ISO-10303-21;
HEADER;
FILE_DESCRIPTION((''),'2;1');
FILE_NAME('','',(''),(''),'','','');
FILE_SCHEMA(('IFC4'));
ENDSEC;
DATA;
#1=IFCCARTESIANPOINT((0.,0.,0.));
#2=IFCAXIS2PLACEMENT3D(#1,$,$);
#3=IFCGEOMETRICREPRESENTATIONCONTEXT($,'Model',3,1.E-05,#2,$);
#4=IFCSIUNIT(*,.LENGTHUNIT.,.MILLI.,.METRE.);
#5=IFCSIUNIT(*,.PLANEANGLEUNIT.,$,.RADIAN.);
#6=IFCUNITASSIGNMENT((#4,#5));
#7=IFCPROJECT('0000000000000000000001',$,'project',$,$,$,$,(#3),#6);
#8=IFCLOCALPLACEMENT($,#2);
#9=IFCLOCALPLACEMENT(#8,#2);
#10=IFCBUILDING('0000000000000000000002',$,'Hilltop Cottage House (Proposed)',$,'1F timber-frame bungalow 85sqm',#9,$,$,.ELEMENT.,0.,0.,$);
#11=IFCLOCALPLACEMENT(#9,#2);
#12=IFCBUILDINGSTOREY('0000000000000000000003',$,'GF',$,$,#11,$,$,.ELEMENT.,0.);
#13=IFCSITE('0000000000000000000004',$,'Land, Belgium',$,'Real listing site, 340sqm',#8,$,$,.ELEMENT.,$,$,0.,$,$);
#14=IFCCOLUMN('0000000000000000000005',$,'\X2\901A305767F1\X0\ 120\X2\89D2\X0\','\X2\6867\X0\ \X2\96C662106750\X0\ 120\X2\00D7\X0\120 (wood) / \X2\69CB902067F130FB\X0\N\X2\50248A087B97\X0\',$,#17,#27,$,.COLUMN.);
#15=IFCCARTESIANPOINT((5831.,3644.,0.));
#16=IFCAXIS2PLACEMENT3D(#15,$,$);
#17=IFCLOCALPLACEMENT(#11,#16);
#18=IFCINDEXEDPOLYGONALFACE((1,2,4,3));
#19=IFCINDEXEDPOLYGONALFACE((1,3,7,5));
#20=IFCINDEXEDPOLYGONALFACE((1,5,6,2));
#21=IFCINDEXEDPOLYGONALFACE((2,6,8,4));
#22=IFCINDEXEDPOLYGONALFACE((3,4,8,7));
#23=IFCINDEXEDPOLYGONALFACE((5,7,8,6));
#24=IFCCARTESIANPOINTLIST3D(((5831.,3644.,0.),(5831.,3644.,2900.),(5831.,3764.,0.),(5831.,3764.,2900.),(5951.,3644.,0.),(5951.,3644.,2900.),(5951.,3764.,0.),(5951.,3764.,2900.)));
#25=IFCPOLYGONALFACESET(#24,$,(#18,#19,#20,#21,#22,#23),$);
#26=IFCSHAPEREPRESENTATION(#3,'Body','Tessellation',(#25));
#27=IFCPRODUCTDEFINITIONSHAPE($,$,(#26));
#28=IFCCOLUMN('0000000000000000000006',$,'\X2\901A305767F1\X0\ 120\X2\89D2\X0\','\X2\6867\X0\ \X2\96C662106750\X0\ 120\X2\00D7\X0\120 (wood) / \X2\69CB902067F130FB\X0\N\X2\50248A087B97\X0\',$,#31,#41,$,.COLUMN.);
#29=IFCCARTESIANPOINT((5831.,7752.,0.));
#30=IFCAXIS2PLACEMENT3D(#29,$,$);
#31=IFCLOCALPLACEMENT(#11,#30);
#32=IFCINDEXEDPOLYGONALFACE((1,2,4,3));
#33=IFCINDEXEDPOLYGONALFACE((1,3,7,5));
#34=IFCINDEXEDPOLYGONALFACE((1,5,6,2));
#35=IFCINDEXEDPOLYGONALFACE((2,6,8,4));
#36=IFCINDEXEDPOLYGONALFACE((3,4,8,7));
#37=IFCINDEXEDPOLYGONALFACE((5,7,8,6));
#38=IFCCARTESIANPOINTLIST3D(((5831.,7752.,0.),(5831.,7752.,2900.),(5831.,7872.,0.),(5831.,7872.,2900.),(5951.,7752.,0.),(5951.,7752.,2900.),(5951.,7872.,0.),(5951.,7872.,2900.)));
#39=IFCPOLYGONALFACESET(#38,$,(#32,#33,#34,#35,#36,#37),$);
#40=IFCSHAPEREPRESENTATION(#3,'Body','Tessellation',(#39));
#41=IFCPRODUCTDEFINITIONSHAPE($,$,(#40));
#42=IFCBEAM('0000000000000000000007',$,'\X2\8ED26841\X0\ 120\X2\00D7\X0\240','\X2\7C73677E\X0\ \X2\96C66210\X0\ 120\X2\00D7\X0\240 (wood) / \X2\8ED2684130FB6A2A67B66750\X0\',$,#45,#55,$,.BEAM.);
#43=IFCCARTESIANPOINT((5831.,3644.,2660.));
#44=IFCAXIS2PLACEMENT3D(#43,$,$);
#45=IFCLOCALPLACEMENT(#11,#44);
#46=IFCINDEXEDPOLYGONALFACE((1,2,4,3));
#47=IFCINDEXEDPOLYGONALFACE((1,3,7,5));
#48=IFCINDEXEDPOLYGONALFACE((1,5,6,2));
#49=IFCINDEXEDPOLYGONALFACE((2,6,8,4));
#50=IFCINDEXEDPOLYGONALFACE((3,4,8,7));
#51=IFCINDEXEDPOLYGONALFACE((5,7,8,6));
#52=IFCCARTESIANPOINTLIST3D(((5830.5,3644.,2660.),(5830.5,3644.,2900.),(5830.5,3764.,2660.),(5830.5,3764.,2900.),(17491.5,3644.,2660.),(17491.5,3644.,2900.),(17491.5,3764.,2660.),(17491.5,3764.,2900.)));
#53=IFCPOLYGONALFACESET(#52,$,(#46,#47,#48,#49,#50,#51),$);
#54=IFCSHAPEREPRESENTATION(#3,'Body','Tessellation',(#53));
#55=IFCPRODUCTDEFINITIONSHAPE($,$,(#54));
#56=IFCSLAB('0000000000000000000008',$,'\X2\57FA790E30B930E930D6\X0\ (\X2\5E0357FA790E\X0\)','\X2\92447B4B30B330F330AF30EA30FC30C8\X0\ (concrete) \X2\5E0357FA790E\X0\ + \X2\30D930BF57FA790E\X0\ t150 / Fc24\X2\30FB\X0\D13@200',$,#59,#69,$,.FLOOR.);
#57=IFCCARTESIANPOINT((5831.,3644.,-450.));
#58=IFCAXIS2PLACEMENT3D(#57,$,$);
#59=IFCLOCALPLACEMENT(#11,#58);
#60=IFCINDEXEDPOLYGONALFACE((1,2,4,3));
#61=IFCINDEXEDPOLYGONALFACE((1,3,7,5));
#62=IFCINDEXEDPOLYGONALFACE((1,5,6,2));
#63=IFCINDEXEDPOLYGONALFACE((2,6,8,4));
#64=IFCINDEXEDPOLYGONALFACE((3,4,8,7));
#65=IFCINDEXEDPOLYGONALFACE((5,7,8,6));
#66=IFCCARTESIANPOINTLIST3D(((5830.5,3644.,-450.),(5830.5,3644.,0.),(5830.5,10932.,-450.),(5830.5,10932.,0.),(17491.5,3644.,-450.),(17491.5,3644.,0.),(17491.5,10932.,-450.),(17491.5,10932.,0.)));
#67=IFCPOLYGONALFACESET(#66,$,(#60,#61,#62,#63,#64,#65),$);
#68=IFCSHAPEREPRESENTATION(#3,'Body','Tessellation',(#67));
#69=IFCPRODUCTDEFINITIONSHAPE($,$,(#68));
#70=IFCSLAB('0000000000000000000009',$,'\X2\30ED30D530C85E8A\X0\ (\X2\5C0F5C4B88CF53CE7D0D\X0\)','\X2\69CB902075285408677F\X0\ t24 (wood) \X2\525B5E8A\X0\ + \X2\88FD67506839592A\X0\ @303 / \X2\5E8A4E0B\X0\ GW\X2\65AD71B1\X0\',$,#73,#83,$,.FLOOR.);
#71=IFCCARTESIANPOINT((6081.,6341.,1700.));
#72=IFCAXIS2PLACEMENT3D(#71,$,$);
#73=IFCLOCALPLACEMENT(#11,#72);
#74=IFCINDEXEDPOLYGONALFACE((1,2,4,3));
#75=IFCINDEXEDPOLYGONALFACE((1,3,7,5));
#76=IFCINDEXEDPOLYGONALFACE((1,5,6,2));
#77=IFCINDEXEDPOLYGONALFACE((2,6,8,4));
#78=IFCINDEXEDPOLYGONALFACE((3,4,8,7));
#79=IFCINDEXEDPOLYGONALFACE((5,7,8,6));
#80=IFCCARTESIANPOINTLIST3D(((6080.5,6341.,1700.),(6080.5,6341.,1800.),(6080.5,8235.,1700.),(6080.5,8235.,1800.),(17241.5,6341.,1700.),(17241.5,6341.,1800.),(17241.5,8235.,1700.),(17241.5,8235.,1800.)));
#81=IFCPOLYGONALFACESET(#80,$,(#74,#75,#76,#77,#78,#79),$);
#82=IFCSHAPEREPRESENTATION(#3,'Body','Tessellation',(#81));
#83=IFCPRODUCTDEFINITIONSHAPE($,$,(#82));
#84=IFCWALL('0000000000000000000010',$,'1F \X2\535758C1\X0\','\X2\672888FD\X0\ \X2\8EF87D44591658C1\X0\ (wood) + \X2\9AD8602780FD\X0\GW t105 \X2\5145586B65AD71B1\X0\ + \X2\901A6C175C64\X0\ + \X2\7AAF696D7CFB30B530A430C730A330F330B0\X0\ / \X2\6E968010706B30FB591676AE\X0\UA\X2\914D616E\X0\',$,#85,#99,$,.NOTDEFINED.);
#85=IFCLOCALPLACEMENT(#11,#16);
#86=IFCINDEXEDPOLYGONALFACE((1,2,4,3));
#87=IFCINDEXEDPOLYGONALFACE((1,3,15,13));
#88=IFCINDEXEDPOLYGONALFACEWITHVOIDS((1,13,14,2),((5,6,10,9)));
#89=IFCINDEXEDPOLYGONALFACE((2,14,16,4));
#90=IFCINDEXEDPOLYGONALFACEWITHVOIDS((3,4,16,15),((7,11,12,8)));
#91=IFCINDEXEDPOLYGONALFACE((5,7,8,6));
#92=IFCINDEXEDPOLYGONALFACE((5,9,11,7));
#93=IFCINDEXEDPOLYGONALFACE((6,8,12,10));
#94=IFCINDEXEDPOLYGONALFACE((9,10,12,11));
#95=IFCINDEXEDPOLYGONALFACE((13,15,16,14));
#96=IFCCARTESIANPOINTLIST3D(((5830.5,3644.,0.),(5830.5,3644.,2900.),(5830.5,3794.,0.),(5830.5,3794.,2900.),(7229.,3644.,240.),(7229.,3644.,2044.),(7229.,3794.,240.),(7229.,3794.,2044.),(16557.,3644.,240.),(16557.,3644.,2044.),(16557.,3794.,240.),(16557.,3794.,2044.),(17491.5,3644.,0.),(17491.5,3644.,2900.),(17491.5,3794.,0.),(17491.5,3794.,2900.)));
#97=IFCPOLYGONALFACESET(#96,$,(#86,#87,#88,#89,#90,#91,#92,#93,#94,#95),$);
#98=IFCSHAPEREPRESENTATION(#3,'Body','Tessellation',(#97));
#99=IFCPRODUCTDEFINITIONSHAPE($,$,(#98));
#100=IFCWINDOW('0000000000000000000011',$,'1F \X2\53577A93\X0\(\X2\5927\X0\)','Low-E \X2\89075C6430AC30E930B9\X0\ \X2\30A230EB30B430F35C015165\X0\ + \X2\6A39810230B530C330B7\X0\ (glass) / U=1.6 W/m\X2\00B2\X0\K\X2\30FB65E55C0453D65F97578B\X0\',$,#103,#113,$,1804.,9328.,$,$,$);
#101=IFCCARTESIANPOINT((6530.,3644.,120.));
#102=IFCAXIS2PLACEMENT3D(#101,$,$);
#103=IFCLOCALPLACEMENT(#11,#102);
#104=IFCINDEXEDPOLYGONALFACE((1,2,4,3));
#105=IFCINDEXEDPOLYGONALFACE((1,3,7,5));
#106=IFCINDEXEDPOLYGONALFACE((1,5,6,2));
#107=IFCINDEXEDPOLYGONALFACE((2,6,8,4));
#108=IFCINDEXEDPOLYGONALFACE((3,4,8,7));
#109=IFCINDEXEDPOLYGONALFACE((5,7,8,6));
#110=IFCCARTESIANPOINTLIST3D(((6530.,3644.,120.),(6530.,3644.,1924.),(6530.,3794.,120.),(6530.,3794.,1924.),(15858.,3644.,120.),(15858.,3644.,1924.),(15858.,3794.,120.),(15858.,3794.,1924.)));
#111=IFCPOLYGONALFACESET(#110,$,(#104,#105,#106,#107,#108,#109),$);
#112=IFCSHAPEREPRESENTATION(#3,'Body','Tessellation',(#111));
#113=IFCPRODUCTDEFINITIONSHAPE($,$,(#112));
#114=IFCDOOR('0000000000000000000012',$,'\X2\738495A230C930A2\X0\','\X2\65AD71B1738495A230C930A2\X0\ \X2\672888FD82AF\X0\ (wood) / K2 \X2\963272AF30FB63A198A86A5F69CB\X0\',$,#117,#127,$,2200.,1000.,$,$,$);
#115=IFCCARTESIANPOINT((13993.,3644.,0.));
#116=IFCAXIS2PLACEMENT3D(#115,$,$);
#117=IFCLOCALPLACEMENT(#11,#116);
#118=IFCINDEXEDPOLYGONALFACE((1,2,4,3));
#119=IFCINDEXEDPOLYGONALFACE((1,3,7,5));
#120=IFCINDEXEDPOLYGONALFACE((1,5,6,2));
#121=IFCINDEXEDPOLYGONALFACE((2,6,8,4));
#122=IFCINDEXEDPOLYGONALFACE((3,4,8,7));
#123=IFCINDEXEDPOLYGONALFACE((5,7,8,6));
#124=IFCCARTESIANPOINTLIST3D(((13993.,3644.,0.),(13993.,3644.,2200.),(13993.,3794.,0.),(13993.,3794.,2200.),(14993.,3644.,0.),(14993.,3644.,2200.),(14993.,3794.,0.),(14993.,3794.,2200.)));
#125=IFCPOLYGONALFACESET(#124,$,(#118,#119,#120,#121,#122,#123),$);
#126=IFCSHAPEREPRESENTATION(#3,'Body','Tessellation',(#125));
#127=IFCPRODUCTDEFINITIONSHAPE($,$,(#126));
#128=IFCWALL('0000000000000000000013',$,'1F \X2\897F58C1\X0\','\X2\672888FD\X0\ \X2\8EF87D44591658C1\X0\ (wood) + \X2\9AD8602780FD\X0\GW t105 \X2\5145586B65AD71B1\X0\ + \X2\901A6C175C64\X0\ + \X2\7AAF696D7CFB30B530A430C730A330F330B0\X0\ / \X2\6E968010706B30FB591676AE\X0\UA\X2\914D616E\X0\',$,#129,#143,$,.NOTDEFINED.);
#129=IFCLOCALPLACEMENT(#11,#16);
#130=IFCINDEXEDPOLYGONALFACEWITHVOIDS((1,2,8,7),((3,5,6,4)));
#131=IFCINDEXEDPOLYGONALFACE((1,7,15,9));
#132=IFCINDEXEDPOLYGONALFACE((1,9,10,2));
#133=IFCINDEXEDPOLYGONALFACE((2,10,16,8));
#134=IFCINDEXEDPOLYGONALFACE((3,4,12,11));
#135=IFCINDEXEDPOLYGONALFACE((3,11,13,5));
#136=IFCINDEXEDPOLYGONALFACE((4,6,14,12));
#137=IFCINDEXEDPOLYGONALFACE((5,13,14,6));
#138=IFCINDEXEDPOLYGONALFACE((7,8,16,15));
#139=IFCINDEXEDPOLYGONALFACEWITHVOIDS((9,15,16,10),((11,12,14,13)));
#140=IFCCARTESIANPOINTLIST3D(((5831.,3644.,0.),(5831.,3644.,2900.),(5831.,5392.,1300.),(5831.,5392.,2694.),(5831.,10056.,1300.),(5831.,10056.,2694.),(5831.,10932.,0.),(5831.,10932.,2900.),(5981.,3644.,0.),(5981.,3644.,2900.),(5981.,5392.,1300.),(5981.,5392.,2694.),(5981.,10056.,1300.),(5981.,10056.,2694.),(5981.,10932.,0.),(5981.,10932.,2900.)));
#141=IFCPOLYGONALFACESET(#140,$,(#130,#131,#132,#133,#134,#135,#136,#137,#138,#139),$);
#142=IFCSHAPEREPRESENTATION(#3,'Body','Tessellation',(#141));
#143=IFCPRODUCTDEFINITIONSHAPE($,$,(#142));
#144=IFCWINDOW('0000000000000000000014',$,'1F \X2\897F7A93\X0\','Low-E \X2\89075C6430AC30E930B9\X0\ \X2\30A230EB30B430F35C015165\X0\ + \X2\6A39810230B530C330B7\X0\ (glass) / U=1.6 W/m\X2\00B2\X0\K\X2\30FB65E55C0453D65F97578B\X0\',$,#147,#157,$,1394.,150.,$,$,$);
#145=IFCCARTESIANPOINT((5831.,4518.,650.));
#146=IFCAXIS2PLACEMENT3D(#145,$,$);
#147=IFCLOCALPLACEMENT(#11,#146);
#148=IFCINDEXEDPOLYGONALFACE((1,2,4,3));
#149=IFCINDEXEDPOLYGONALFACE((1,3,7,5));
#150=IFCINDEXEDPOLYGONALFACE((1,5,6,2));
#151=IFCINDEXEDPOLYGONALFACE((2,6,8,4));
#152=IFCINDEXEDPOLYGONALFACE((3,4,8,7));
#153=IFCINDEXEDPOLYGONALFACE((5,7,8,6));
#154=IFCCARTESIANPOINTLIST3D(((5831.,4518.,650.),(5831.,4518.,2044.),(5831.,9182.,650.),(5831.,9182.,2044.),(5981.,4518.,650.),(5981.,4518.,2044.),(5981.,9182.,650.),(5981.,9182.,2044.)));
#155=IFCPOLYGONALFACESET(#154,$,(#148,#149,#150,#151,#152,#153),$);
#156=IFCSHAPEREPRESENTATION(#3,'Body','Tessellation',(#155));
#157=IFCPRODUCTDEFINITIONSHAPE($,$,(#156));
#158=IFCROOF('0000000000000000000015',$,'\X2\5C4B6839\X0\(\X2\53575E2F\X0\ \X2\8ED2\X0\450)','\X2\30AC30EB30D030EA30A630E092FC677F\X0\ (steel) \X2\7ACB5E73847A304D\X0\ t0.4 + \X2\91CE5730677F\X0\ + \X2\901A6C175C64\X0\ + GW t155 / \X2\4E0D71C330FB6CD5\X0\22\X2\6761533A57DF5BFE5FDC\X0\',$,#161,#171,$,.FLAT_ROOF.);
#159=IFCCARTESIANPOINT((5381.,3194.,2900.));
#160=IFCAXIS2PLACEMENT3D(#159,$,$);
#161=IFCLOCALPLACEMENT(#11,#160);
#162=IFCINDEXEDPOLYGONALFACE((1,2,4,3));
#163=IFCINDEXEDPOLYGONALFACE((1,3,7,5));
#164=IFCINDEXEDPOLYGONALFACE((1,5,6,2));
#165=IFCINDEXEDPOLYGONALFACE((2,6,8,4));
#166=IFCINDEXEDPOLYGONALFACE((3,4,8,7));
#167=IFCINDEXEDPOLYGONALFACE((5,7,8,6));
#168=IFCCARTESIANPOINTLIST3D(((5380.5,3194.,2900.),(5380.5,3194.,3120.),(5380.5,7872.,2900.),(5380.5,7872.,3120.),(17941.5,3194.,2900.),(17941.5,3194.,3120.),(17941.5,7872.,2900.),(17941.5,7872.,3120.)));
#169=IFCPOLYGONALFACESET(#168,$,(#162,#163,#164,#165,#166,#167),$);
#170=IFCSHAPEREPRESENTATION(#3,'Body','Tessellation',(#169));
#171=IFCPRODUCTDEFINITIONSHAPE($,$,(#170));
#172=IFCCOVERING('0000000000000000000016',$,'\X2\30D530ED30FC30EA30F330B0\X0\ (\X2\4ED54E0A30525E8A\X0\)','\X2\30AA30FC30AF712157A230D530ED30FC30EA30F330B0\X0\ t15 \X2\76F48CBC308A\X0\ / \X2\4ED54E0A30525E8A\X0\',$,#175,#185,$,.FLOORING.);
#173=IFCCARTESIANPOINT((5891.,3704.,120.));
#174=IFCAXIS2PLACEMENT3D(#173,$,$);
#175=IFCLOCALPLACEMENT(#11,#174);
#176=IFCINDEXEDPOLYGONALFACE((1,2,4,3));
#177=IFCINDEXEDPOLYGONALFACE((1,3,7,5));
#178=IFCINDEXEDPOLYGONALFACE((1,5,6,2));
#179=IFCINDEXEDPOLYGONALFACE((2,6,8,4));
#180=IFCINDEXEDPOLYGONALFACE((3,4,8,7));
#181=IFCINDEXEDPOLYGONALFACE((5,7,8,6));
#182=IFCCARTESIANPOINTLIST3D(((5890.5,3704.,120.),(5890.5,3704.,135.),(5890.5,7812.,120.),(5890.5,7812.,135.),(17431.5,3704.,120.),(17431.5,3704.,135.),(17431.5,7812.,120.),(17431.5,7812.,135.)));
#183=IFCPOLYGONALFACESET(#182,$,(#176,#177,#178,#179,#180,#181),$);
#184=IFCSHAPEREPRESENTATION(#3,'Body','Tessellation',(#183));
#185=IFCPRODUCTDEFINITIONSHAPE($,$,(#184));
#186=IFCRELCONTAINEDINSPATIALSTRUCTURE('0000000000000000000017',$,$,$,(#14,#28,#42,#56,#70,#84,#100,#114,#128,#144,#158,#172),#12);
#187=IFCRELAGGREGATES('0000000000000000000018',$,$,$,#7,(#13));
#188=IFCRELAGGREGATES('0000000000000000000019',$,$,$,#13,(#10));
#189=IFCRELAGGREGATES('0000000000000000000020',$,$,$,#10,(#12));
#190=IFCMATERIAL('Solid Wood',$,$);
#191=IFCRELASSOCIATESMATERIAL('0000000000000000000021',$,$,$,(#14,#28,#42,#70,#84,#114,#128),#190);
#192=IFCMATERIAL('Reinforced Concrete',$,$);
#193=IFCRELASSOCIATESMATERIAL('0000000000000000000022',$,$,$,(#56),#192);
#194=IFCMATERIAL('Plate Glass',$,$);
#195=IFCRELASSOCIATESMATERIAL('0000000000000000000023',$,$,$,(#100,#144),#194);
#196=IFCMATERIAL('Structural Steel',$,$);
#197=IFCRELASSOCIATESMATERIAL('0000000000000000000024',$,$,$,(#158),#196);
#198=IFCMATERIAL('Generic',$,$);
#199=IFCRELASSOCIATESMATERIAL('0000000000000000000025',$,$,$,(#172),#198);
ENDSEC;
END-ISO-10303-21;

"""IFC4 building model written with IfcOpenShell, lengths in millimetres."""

from ifc_helpers import new_model, si_unit, frame, frame_2d, origin, place, context, project, spatial, rectangle, extrude, material, element, fill, save


model = new_model("IFC4")

# Units and contexts
model_context = context("Model", 3, precision=1e-05, world=origin())
ifc_project = project(units=[si_unit("LENGTHUNIT", "METRE", prefix="MILLI"), si_unit("PLANEANGLEUNIT", "RADIAN")], contexts=[model_context])

# Site, building, storey
site_placement = place(None, origin())
site = spatial("IfcSite", under=ifc_project, at=site_placement, Name="Land, Belgium", ObjectType="Real listing site, 340sqm", CompositionType="ELEMENT", RefElevation=0.0)
building_placement = place(site_placement, origin())
building = spatial("IfcBuilding", under=site, at=building_placement, Name="Hilltop Cottage House (Proposed)", ObjectType="1F timber-frame bungalow 85sqm", CompositionType="ELEMENT", ElevationOfRefHeight=0.0, ElevationOfTerrain=0.0)
storey_placement = place(building_placement, origin())
storey = spatial("IfcBuildingStorey", under=building, at=storey_placement, Name="GF", CompositionType="ELEMENT", Elevation=0.0)

# Columns
ifc_material_1 = material(Name="Solid Wood")
column_1_placement = place(storey_placement, frame((5831.0, 3644.0, 0.0)))
element("IfcColumn", 1, at=column_1_placement, inside=storey, material=ifc_material_1, Name="通し柱 120角", Description="桧 集成材 120×120 (wood) / 構造柱・N値計算", PredefinedType="COLUMN", context=model_context, shape_type="SweptSolid", body=[
    extrude(rectangle(XDim=120.0, YDim=120.0, at=frame_2d((60.0, 60.0))), frame((5831.0, 3644.0, 0.0)), (0.0, 0.0, 1.0), 2900.0),
])
column_2_placement = place(storey_placement, frame((5831.0, 7752.0, 0.0)))
element("IfcColumn", 2, at=column_2_placement, inside=storey, material=ifc_material_1, Name="通し柱 120角", Description="桧 集成材 120×120 (wood) / 構造柱・N値計算", PredefinedType="COLUMN", context=model_context, shape_type="SweptSolid", body=[
    extrude(rectangle(XDim=120.0, YDim=120.0, at=frame_2d((60.0, 60.0))), frame((5831.0, 7752.0, 0.0)), (0.0, 0.0, 1.0), 2900.0),
])

# Beam
beam_1_placement = place(storey_placement, frame((5831.0, 3644.0, 2660.0)))
element("IfcBeam", 3, at=beam_1_placement, inside=storey, material=ifc_material_1, Name="軒桁 120×240", Description="米松 集成 120×240 (wood) / 軒桁・横架材", PredefinedType="BEAM", context=model_context, shape_type="SweptSolid", body=[
    extrude(rectangle(XDim=11661.0, YDim=120.0, at=frame_2d((5830.0, 60.0))), frame((5831.0, 3644.0, 2660.0)), (0.0, 0.0, 1.0), 240.0),
])

# Slabs
ifc_material_2 = material(Name="Reinforced Concrete")
slab_1_placement = place(storey_placement, frame((5831.0, 3644.0, -450.0)))
element("IfcSlab", 4, at=slab_1_placement, inside=storey, material=ifc_material_2, Name="基礎スラブ (布基礎)", Description="鉄筋コンクリート (concrete) 布基礎 + ベタ基礎 t150 / Fc24・D13@200", PredefinedType="FLOOR", context=model_context, shape_type="SweptSolid", body=[
    extrude(rectangle(XDim=11661.0, YDim=7288.0, at=frame_2d((5830.0, 3644.0))), frame((5831.0, 3644.0, -450.0)), (0.0, 0.0, 1.0), 450.0),
])
slab_2_placement = place(storey_placement, frame((6081.0, 6341.0, 1700.0)))
element("IfcSlab", 5, at=slab_2_placement, inside=storey, material=ifc_material_1, Name="ロフト床 (小屋裏収納)", Description="構造用合板 t24 (wood) 剛床 + 製材根太 @303 / 床下 GW断熱", PredefinedType="FLOOR", context=model_context, shape_type="SweptSolid", body=[
    extrude(rectangle(XDim=11161.0, YDim=1894.0, at=frame_2d((5580.0, 947.0))), frame((6081.0, 6341.0, 1700.0)), (0.0, 0.0, 1.0), 100.0),
])

# Wall, openings, window, door
wall_1_placement = place(storey_placement, frame((5831.0, 3644.0, 0.0)))
wall_1 = element("IfcWall", 6, at=wall_1_placement, inside=storey, material=ifc_material_1, Name="1F 南壁", Description="木製 軸組外壁 (wood) + 高性能GW t105 充填断熱 + 通気層 + 窯業系サイディング / 準耐火・外皮UA配慮", PredefinedType="NOTDEFINED", context=model_context, shape_type="SweptSolid", body=[
    extrude(rectangle(XDim=11661.0, YDim=150.0, at=frame_2d((5830.0, 75.0))), frame((5831.0, 3644.0, 0.0)), (0.0, 0.0, 1.0), 2900.0),
])
opening_1_placement = place(storey_placement, frame((6530.0, 3644.0, 120.0)))
opening_1 = element("IfcOpeningElement", 7, at=opening_1_placement, cuts=wall_1, PredefinedType="NOTDEFINED", context=model_context, shape_type="SweptSolid", body=[
    extrude(rectangle(XDim=9328.0, YDim=150.0, at=frame_2d((4664.0, 75.0))), frame((6530.0, 3644.0, 120.0)), (0.0, 0.0, 1.0), 1804.0),
])
opening_2_placement = place(storey_placement, frame((13993.0, 3644.0, 0.0)))
opening_2 = element("IfcOpeningElement", 8, at=opening_2_placement, cuts=wall_1, PredefinedType="NOTDEFINED", context=model_context, shape_type="SweptSolid", body=[
    extrude(rectangle(XDim=1000.0, YDim=150.0, at=frame_2d((500.0, 75.0))), frame((13993.0, 3644.0, 0.0)), (0.0, 0.0, 1.0), 2200.0),
])
ifc_material_3 = material(Name="Plate Glass")
window_1_placement = place(storey_placement, frame((6530.0, 3644.0, 120.0)))
window_1 = element("IfcWindow", 9, at=window_1_placement, inside=storey, material=ifc_material_3, Name="1F 南窓(大)", Description="Low-E 複層ガラス アルゴン封入 + 樹脂サッシ (glass) / U=1.6 W/m²K・日射取得型", OverallHeight=1804.0, OverallWidth=9328.0, context=model_context, shape_type="SweptSolid", body=[
    extrude(rectangle(XDim=9328.0, YDim=150.0, at=frame_2d((4664.0, 75.0))), frame((6530.0, 3644.0, 120.0)), (0.0, 0.0, 1.0), 1804.0),
])
fill(opening_1, window_1)
door_placement = place(storey_placement, frame((13993.0, 3644.0, 0.0)))
door = element("IfcDoor", 10, at=door_placement, inside=storey, material=ifc_material_1, Name="玄関ドア", Description="断熱玄関ドア 木製芯 (wood) / K2 防犯・採風機構", OverallHeight=2200.0, OverallWidth=1000.0, context=model_context, shape_type="SweptSolid", body=[
    extrude(rectangle(XDim=1000.0, YDim=150.0, at=frame_2d((500.0, 75.0))), frame((13993.0, 3644.0, 0.0)), (0.0, 0.0, 1.0), 2200.0),
])
fill(opening_2, door)

# Wall, opening, window
wall_2_placement = place(storey_placement, frame((5831.0, 3644.0, 0.0)))
wall_2 = element("IfcWall", 11, at=wall_2_placement, inside=storey, material=ifc_material_1, Name="1F 西壁", Description="木製 軸組外壁 (wood) + 高性能GW t105 充填断熱 + 通気層 + 窯業系サイディング / 準耐火・外皮UA配慮", PredefinedType="NOTDEFINED", context=model_context, shape_type="SweptSolid", body=[
    extrude(rectangle(XDim=150.0, YDim=7288.0, at=frame_2d((75.0, 3644.0))), frame((5831.0, 3644.0, 0.0)), (0.0, 0.0, 1.0), 2900.0),
])
opening_3_placement = place(storey_placement, frame((5831.0, 4518.0, 650.0)))
opening_3 = element("IfcOpeningElement", 12, at=opening_3_placement, cuts=wall_2, PredefinedType="NOTDEFINED", context=model_context, shape_type="SweptSolid", body=[
    extrude(rectangle(XDim=150.0, YDim=4664.0, at=frame_2d((75.0, 2332.0))), frame((5831.0, 4518.0, 650.0)), (0.0, 0.0, 1.0), 1394.0),
])
window_2_placement = place(storey_placement, frame((5831.0, 4518.0, 650.0)))
window_2 = element("IfcWindow", 13, at=window_2_placement, inside=storey, material=ifc_material_3, Name="1F 西窓", Description="Low-E 複層ガラス アルゴン封入 + 樹脂サッシ (glass) / U=1.6 W/m²K・日射取得型", OverallHeight=1394.0, OverallWidth=150.0, context=model_context, shape_type="SweptSolid", body=[
    extrude(rectangle(XDim=150.0, YDim=4664.0, at=frame_2d((75.0, 2332.0))), frame((5831.0, 4518.0, 650.0)), (0.0, 0.0, 1.0), 1394.0),
])
fill(opening_3, window_2)

# Roof
ifc_material_4 = material(Name="Structural Steel")
roof_placement = place(storey_placement, frame((5381.0, 3194.0, 2900.0)))
element("IfcRoof", 14, at=roof_placement, inside=storey, material=ifc_material_4, Name="屋根(南帯 軒450)", Description="ガルバリウム鋼板 (steel) 立平葺き t0.4 + 野地板 + 通気層 + GW t155 / 不燃・法22条区域対応", PredefinedType="FLAT_ROOF", context=model_context, shape_type="SweptSolid", body=[
    extrude(rectangle(XDim=12561.0, YDim=4678.0, at=frame_2d((6280.0, 2339.0))), frame((5381.0, 3194.0, 2900.0)), (0.0, 0.0, 1.0), 220.0),
])

# Covering
ifc_material_5 = material(Name="Generic")
covering_1_placement = place(storey_placement, frame((5891.0, 3704.0, 120.0)))
element("IfcCovering", 15, at=covering_1_placement, inside=storey, material=ifc_material_5, Name="フローリング (仕上げ床)", Description="オーク無垢フローリング t15 直貼り / 仕上げ床", PredefinedType="FLOORING", context=model_context, shape_type="SweptSolid", body=[
    extrude(rectangle(XDim=11541.0, YDim=4108.0, at=frame_2d((5770.0, 2054.0))), frame((5891.0, 3704.0, 120.0)), (0.0, 0.0, 1.0), 15.0),
])

save(model, "model.ifc")
